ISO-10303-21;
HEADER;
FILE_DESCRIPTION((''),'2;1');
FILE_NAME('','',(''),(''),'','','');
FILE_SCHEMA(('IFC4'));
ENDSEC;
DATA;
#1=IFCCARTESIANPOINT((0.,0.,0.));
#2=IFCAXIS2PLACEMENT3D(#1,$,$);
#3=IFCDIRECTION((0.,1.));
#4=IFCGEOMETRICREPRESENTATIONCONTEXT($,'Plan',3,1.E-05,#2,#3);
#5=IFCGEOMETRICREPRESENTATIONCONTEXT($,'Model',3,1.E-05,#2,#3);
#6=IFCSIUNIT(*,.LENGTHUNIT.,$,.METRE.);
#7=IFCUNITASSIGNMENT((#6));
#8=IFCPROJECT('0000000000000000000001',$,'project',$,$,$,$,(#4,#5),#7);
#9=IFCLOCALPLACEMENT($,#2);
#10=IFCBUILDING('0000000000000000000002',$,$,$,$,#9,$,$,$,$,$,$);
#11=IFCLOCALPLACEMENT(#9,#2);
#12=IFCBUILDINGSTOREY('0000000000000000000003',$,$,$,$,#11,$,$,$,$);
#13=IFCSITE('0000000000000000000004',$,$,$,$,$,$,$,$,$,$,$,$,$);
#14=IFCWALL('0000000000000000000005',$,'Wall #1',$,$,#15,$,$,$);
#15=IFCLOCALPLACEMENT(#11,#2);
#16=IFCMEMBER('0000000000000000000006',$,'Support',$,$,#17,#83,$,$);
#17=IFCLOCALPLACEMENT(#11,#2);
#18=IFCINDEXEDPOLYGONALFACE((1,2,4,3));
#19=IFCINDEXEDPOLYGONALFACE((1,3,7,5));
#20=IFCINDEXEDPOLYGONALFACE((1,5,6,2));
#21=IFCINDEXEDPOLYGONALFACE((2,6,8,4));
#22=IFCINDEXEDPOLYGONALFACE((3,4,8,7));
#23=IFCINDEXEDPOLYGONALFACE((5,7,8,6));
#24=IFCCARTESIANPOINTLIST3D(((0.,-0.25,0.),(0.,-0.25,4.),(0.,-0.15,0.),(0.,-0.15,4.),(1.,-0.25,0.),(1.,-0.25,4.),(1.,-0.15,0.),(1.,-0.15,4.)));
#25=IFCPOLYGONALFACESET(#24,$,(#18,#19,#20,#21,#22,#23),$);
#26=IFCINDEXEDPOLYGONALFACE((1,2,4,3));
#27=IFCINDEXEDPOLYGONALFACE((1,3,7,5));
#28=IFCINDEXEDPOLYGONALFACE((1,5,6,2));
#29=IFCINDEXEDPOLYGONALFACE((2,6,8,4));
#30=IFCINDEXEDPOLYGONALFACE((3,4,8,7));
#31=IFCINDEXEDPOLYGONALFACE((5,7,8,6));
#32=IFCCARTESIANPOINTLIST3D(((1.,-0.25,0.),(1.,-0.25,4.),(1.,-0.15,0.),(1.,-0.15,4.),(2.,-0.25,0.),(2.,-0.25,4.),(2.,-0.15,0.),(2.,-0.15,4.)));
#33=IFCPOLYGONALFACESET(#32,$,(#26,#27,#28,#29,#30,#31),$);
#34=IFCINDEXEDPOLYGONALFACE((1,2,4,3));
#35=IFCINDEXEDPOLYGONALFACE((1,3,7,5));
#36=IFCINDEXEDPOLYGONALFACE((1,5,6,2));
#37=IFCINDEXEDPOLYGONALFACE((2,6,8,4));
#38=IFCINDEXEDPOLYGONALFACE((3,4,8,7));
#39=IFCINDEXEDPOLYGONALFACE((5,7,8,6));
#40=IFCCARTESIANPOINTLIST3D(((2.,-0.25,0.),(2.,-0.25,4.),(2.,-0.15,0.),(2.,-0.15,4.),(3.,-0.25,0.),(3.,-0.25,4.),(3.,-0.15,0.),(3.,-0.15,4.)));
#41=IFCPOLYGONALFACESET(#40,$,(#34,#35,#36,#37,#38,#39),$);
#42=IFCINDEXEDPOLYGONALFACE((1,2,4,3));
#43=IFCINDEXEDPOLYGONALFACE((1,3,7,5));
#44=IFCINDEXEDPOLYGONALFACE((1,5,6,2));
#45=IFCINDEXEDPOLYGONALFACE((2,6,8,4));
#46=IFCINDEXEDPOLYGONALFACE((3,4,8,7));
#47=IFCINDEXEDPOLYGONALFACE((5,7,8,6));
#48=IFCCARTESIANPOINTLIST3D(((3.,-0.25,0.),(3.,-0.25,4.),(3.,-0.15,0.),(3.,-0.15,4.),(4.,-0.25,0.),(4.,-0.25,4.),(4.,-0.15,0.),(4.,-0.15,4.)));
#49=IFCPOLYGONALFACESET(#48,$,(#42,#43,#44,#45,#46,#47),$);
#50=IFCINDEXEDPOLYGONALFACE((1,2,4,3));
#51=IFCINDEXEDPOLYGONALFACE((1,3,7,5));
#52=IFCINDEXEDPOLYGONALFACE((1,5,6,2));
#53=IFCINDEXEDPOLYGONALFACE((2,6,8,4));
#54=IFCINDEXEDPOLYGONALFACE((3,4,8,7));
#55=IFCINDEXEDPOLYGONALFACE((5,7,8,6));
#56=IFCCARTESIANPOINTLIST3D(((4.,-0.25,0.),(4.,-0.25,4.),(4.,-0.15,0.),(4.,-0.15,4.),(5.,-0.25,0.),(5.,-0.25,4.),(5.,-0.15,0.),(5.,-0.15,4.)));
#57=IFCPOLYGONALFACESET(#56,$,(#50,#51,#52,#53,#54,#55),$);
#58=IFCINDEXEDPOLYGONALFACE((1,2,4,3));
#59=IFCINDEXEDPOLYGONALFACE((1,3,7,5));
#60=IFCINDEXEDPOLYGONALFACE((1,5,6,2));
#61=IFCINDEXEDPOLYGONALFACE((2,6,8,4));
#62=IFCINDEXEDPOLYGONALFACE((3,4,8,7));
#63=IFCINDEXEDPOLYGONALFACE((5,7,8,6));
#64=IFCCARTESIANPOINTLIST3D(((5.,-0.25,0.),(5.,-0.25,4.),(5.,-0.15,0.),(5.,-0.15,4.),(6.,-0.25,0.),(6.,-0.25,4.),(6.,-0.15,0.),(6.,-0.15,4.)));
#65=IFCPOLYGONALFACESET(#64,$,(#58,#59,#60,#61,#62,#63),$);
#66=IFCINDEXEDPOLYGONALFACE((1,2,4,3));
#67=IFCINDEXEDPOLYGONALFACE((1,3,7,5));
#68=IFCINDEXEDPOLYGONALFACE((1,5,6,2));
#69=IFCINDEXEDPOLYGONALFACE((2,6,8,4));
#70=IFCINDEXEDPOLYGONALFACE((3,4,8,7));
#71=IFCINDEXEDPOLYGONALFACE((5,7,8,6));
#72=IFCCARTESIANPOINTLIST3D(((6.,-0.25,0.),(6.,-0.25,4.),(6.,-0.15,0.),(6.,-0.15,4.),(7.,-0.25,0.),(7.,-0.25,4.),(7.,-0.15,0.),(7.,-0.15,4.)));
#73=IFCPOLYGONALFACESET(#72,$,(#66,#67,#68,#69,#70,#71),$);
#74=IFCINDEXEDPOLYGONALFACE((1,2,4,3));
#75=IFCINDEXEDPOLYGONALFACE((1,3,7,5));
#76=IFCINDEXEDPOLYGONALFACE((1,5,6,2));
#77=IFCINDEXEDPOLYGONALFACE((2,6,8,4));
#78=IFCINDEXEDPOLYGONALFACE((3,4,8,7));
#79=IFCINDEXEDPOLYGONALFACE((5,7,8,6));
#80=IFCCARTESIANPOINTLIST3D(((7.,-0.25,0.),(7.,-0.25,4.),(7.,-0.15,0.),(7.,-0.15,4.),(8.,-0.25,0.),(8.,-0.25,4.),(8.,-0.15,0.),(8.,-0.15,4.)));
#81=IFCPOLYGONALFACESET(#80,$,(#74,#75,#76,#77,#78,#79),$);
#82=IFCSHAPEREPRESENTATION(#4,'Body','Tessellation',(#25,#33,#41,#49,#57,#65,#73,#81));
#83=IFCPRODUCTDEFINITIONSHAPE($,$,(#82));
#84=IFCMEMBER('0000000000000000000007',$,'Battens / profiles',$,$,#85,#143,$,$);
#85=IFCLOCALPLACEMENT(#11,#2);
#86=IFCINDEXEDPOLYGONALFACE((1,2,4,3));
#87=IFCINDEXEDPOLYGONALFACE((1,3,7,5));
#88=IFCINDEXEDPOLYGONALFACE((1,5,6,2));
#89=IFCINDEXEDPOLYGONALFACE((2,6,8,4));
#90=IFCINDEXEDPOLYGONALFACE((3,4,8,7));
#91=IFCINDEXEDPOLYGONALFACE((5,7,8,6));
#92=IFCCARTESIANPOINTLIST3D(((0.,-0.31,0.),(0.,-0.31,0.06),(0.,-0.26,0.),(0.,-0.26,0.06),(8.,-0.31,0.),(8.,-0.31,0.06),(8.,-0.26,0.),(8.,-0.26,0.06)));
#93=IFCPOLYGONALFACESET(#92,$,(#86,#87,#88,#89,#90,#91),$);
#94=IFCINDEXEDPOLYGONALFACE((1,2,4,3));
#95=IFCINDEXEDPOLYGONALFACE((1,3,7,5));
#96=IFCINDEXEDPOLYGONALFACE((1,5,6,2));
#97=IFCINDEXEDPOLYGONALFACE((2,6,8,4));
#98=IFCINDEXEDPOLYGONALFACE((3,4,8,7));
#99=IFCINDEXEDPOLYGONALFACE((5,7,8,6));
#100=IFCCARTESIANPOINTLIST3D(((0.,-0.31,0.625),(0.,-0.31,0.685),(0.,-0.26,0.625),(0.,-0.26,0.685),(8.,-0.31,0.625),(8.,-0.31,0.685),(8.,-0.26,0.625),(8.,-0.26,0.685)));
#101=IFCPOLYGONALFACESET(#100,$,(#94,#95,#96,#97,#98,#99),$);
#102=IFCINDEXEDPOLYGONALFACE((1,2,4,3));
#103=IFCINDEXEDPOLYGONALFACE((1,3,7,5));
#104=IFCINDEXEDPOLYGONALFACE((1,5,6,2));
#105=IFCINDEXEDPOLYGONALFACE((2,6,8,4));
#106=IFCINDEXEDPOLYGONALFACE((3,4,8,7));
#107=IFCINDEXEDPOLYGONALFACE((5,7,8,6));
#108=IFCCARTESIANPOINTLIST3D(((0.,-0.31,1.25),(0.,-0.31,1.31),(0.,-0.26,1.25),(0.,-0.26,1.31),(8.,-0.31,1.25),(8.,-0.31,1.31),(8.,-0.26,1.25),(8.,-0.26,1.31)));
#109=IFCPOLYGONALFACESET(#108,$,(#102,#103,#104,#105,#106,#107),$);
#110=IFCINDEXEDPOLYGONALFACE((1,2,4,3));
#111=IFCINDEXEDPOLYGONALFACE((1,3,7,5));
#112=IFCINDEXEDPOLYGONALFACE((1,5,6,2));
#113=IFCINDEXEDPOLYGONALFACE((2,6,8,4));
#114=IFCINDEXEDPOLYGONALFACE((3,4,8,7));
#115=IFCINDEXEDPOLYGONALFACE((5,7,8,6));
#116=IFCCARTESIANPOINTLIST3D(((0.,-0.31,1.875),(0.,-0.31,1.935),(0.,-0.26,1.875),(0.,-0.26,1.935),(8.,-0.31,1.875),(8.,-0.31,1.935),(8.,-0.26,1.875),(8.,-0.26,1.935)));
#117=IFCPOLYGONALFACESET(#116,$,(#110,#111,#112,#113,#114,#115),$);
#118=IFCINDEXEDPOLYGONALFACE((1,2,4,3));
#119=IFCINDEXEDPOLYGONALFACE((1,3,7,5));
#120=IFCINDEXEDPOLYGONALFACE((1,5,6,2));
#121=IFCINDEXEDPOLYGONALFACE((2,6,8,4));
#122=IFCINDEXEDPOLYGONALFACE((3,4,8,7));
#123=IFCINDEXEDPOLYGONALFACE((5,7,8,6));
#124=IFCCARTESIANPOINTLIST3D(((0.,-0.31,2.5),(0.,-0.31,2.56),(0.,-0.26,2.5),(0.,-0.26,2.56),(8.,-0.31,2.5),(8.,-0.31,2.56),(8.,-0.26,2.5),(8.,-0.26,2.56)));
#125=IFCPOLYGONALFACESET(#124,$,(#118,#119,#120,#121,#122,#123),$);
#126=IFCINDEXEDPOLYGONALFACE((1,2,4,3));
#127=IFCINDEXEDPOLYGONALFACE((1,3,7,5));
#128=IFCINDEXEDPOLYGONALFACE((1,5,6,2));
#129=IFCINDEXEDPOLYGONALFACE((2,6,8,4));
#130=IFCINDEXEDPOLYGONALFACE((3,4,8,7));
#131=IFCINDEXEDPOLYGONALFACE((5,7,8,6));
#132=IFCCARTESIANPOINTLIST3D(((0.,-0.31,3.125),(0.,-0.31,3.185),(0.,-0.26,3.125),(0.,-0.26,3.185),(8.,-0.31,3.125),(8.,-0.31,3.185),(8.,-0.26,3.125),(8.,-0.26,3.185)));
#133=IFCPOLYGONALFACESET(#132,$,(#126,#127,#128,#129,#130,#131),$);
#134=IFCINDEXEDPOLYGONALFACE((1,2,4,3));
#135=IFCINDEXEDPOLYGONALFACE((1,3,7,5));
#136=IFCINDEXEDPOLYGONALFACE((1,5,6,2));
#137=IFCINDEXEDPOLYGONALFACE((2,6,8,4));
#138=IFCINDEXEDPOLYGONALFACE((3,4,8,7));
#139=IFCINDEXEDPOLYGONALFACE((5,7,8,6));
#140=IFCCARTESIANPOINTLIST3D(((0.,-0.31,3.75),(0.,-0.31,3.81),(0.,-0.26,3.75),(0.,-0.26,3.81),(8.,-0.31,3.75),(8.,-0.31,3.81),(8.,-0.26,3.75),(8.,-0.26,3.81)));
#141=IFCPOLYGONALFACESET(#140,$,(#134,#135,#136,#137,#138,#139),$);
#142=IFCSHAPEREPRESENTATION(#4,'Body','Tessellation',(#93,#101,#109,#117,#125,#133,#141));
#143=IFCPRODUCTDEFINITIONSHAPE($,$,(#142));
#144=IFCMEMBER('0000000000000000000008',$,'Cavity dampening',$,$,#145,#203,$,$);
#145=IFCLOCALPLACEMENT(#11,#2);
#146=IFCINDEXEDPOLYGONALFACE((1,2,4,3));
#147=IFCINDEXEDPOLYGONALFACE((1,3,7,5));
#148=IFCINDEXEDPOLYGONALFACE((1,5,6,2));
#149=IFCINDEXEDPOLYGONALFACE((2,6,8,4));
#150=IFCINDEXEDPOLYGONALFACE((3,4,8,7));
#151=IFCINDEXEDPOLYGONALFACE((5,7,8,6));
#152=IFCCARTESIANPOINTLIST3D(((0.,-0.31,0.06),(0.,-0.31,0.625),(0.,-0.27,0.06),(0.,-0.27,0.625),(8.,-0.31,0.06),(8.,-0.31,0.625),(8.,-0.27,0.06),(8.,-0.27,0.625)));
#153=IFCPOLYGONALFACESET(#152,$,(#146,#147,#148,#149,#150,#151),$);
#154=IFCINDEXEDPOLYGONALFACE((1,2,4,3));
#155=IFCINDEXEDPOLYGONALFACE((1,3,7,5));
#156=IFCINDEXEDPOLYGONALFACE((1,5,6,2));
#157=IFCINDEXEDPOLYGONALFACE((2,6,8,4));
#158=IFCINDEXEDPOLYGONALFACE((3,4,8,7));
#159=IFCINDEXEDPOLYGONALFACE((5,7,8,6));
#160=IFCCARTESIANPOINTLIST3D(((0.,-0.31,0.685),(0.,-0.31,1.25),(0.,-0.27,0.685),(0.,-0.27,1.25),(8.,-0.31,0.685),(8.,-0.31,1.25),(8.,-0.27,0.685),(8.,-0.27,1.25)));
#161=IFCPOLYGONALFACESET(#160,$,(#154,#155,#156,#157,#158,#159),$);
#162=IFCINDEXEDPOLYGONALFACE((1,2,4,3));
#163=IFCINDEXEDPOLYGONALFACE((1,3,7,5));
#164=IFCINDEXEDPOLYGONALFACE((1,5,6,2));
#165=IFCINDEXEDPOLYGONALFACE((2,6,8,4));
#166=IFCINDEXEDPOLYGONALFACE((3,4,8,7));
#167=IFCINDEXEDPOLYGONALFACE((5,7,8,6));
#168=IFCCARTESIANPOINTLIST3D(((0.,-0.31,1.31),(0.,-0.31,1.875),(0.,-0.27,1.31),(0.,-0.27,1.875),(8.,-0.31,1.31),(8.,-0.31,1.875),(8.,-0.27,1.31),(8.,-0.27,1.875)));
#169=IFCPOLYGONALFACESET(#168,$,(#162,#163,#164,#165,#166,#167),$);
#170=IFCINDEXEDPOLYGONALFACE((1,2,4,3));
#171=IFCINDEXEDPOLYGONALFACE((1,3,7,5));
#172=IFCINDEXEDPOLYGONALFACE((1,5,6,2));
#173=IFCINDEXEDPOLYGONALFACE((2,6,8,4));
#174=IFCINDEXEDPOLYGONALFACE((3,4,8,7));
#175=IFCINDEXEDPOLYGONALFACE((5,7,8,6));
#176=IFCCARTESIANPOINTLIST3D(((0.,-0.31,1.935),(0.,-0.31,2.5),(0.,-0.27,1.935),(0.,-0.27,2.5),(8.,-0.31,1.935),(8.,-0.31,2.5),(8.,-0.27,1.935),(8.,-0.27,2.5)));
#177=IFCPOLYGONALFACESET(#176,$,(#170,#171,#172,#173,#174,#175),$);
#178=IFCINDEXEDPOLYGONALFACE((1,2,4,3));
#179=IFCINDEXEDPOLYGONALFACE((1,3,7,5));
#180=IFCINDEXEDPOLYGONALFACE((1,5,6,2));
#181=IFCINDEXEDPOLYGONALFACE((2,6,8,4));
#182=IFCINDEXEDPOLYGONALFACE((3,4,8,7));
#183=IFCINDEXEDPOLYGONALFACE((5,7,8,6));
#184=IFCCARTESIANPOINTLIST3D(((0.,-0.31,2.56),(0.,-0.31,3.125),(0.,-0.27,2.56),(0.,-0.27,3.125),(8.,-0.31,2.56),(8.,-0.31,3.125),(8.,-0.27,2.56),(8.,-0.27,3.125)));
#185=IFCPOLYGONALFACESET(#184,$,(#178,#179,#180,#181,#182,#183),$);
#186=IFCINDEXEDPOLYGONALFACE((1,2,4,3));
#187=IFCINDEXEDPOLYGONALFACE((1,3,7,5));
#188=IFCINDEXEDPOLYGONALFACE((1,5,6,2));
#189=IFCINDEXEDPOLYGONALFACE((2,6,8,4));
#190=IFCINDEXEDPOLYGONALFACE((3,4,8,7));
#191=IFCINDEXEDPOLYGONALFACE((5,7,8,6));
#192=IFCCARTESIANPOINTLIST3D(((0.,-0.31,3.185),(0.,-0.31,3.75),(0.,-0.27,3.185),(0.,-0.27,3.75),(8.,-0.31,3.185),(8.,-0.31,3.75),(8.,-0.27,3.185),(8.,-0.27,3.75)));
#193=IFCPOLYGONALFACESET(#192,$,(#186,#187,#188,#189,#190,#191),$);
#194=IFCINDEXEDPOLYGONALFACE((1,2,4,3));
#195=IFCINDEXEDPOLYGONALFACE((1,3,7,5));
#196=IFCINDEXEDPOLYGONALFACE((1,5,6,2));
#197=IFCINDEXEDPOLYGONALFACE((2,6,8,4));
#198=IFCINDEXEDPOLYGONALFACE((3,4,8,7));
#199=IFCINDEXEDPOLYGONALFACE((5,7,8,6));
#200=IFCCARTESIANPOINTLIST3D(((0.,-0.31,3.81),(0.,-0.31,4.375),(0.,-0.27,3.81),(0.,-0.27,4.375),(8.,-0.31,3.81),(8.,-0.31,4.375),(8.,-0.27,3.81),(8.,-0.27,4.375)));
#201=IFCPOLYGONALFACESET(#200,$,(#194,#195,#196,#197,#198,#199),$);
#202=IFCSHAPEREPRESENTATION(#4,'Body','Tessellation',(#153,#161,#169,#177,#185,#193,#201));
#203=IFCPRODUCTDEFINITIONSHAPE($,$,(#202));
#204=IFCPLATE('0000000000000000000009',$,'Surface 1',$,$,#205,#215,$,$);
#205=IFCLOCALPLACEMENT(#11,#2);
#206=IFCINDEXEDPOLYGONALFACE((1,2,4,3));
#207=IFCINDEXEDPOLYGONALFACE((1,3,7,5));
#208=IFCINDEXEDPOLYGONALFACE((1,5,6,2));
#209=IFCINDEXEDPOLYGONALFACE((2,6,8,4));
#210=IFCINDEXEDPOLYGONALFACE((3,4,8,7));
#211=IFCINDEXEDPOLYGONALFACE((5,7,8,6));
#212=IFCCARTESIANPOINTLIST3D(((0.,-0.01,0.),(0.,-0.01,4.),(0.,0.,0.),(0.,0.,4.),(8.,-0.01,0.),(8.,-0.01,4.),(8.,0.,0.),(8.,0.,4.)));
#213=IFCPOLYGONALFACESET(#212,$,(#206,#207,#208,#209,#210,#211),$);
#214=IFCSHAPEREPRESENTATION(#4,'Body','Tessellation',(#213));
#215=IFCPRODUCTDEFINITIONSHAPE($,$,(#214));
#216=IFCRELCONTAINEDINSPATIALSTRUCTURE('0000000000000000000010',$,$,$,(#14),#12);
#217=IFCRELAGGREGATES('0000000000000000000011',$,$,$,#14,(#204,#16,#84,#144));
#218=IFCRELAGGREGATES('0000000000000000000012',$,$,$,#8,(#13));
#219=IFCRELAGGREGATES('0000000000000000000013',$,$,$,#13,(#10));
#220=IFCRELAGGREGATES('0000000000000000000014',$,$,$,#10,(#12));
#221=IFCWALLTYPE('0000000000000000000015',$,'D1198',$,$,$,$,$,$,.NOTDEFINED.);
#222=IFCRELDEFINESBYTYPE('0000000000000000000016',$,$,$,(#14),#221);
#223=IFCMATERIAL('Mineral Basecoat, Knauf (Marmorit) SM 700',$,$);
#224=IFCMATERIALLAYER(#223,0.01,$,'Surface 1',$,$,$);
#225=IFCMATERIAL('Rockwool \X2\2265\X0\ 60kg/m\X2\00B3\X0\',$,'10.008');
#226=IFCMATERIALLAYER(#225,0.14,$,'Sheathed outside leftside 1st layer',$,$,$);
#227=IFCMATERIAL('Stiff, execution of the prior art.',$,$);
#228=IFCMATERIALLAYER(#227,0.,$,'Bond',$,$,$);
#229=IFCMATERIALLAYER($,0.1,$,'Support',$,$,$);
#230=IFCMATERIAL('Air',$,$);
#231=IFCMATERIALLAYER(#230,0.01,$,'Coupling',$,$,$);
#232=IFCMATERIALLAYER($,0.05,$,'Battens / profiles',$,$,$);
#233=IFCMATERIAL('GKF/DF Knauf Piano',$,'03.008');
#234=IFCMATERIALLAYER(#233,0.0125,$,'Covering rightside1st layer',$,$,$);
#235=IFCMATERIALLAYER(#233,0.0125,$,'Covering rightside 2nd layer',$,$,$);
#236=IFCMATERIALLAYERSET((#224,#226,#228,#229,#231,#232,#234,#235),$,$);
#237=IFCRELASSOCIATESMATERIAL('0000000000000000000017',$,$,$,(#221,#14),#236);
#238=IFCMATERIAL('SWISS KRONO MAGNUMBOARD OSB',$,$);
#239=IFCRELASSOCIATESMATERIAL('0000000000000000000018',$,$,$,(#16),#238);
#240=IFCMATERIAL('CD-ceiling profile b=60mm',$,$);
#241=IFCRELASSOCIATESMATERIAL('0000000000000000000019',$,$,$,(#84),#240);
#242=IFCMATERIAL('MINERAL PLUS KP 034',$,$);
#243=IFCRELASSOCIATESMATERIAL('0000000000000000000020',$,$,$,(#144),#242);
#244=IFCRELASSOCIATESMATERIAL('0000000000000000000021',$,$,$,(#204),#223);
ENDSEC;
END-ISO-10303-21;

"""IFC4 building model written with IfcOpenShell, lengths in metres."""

from ifc_helpers import new_model, si_unit, direction, frame, frame_2d, origin, origin_with_axes, place, context, project, spatial, rectangle, extrude, material, layer, layer_set, type_object, element, aggregate, save


model = new_model("IFC4")

# Units and contexts
plan_context = context("Plan", 3, precision=1e-05, world=origin(), true_north=direction((0.0, 1.0)))
model_context = context("Model", 3, precision=1e-05, world=origin(), true_north=direction((0.0, 1.0)))
ifc_project = project(units=[si_unit("LENGTHUNIT", "METRE")], contexts=[plan_context, model_context])

# Site, building, storey
site = spatial("IfcSite", under=ifc_project)
building_placement = place(None, origin())
building = spatial("IfcBuilding", under=site, at=building_placement)
storey_placement = place(building_placement, origin())
storey = spatial("IfcBuildingStorey", under=building, at=storey_placement)

# Wall, members, plate
ifc_material_1 = material(Name="Mineral Basecoat, Knauf (Marmorit) SM 700")
ifc_layer_1 = layer(ifc_material_1, 0.01, Name="Surface 1")
ifc_material_2 = material(Name="Rockwool ≥ 60kg/m³", Category="10.008")
ifc_layer_2 = layer(ifc_material_2, 0.14, Name="Sheathed outside leftside 1st layer")
ifc_material_3 = material(Name="Stiff, execution of the prior art.")
ifc_layer_3 = layer(ifc_material_3, 0.0, Name="Bond")
ifc_layer_4 = layer(None, 0.1, Name="Support")
ifc_material_4 = material(Name="Air")
ifc_layer_5 = layer(ifc_material_4, 0.01, Name="Coupling")
ifc_layer_6 = layer(None, 0.05, Name="Battens / profiles")
ifc_material_5 = material(Name="GKF/DF Knauf Piano", Category="03.008")
ifc_layer_7 = layer(ifc_material_5, 0.0125, Name="Covering rightside1st layer")
ifc_layer_8 = layer(ifc_material_5, 0.0125, Name="Covering rightside 2nd layer")
ifc_layer_set = layer_set([ifc_layer_1, ifc_layer_2, ifc_layer_3, ifc_layer_4, ifc_layer_5, ifc_layer_6, ifc_layer_7, ifc_layer_8])
wall_type = type_object("IfcWallType", Name="D1198", PredefinedType="NOTDEFINED", material=ifc_layer_set)
wall_placement = place(None, frame((0.0, 0.0, 0.0), z_axis=(0.0, -1.0, 0.0), x_axis=(1.0, 0.0, 0.0)))
wall = element("IfcWall", 1, at=wall_placement, inside=storey, type_object=wall_type, material=ifc_layer_set, Name="Wall #1")
ifc_material_6 = material(Name="SWISS KRONO MAGNUMBOARD OSB")
member_1_placement = place(wall_placement, origin())
member_1 = element("IfcMember", 2, at=member_1_placement, material=ifc_material_6, Name="Support", context=plan_context, shape_type="SweptSolid", body=[
    extrude(rectangle(XDim=1.0, YDim=0.1, at=frame_2d((0.5, 0.05), x_axis=(1.0, 0.0))), frame((0.0, 4.0, 0.15), z_axis=(0.0, -1.0, 0.0), x_axis=(1.0, 0.0, 0.0)), (0.0, 0.0, 1.0), 4.0),
    extrude(rectangle(XDim=1.0, YDim=0.1, at=frame_2d((0.5, 0.05), x_axis=(1.0, 0.0))), frame((1.0, 4.0, 0.15), z_axis=(0.0, -1.0, 0.0), x_axis=(1.0, 0.0, 0.0)), (0.0, 0.0, 1.0), 4.0),
    extrude(rectangle(XDim=1.0, YDim=0.1, at=frame_2d((0.5, 0.05), x_axis=(1.0, 0.0))), frame((2.0, 4.0, 0.15), z_axis=(0.0, -1.0, 0.0), x_axis=(1.0, 0.0, 0.0)), (0.0, 0.0, 1.0), 4.0),
    extrude(rectangle(XDim=1.0, YDim=0.1, at=frame_2d((0.5, 0.05), x_axis=(1.0, 0.0))), frame((3.0, 4.0, 0.15), z_axis=(0.0, -1.0, 0.0), x_axis=(1.0, 0.0, 0.0)), (0.0, 0.0, 1.0), 4.0),
    extrude(rectangle(XDim=1.0, YDim=0.1, at=frame_2d((0.5, 0.05), x_axis=(1.0, 0.0))), frame((4.0, 4.0, 0.15), z_axis=(0.0, -1.0, 0.0), x_axis=(1.0, 0.0, 0.0)), (0.0, 0.0, 1.0), 4.0),
    extrude(rectangle(XDim=1.0, YDim=0.1, at=frame_2d((0.5, 0.05), x_axis=(1.0, 0.0))), frame((5.0, 4.0, 0.15), z_axis=(0.0, -1.0, 0.0), x_axis=(1.0, 0.0, 0.0)), (0.0, 0.0, 1.0), 4.0),
    extrude(rectangle(XDim=1.0, YDim=0.1, at=frame_2d((0.5, 0.05), x_axis=(1.0, 0.0))), frame((6.0, 4.0, 0.15), z_axis=(0.0, -1.0, 0.0), x_axis=(1.0, 0.0, 0.0)), (0.0, 0.0, 1.0), 4.0),
    extrude(rectangle(XDim=1.0, YDim=0.1, at=frame_2d((0.5, 0.05), x_axis=(1.0, 0.0))), frame((7.0, 4.0, 0.15), z_axis=(0.0, -1.0, 0.0), x_axis=(1.0, 0.0, 0.0)), (0.0, 0.0, 1.0), 4.0),
])
ifc_material_7 = material(Name="CD-ceiling profile b=60mm")
member_2_placement = place(wall_placement, origin())
member_2 = element("IfcMember", 3, at=member_2_placement, material=ifc_material_7, Name="Battens / profiles", context=plan_context, shape_type="SweptSolid", body=[
    extrude(rectangle(XDim=0.06, YDim=0.05, at=frame_2d((0.03, 0.025), x_axis=(1.0, 0.0))), frame((0.0, 0.0, 0.26), z_axis=(1.0, 0.0, 0.0), x_axis=(0.0, 1.0, 0.0)), (0.0, 0.0, 1.0), 8.0),
    extrude(rectangle(XDim=0.06, YDim=0.05, at=frame_2d((0.03, 0.025), x_axis=(1.0, 0.0))), frame((0.0, 0.625, 0.26), z_axis=(1.0, 0.0, 0.0), x_axis=(0.0, 1.0, 0.0)), (0.0, 0.0, 1.0), 8.0),
    extrude(rectangle(XDim=0.06, YDim=0.05, at=frame_2d((0.03, 0.025), x_axis=(1.0, 0.0))), frame((0.0, 1.25, 0.26), z_axis=(1.0, 0.0, 0.0), x_axis=(0.0, 1.0, 0.0)), (0.0, 0.0, 1.0), 8.0),
    extrude(rectangle(XDim=0.06, YDim=0.05, at=frame_2d((0.03, 0.025), x_axis=(1.0, 0.0))), frame((0.0, 1.875, 0.26), z_axis=(1.0, 0.0, 0.0), x_axis=(0.0, 1.0, 0.0)), (0.0, 0.0, 1.0), 8.0),
    extrude(rectangle(XDim=0.06, YDim=0.05, at=frame_2d((0.03, 0.025), x_axis=(1.0, 0.0))), frame((0.0, 2.5, 0.26), z_axis=(1.0, 0.0, 0.0), x_axis=(0.0, 1.0, 0.0)), (0.0, 0.0, 1.0), 8.0),
    extrude(rectangle(XDim=0.06, YDim=0.05, at=frame_2d((0.03, 0.025), x_axis=(1.0, 0.0))), frame((0.0, 3.125, 0.26), z_axis=(1.0, 0.0, 0.0), x_axis=(0.0, 1.0, 0.0)), (0.0, 0.0, 1.0), 8.0),
    extrude(rectangle(XDim=0.06, YDim=0.05, at=frame_2d((0.03, 0.025), x_axis=(1.0, 0.0))), frame((0.0, 3.75, 0.26), z_axis=(1.0, 0.0, 0.0), x_axis=(0.0, 1.0, 0.0)), (0.0, 0.0, 1.0), 8.0),
])
ifc_material_8 = material(Name="MINERAL PLUS KP 034")
member_3_placement = place(wall_placement, origin())
member_3 = element("IfcMember", 4, at=member_3_placement, material=ifc_material_8, Name="Cavity dampening", context=plan_context, shape_type="SweptSolid", body=[
    extrude(rectangle(XDim=0.565, YDim=0.04, at=frame_2d((0.2825, 0.02), x_axis=(1.0, 0.0))), frame((0.0, 0.06, 0.27), z_axis=(1.0, 0.0, 0.0), x_axis=(0.0, 1.0, 0.0)), (0.0, 0.0, 1.0), 8.0),
    extrude(rectangle(XDim=0.565, YDim=0.04, at=frame_2d((0.2825, 0.02), x_axis=(1.0, 0.0))), frame((0.0, 0.685, 0.27), z_axis=(1.0, 0.0, 0.0), x_axis=(0.0, 1.0, 0.0)), (0.0, 0.0, 1.0), 8.0),
    extrude(rectangle(XDim=0.565, YDim=0.04, at=frame_2d((0.2825, 0.02), x_axis=(1.0, 0.0))), frame((0.0, 1.31, 0.27), z_axis=(1.0, 0.0, 0.0), x_axis=(0.0, 1.0, 0.0)), (0.0, 0.0, 1.0), 8.0),
    extrude(rectangle(XDim=0.565, YDim=0.04, at=frame_2d((0.2825, 0.02), x_axis=(1.0, 0.0))), frame((0.0, 1.935, 0.27), z_axis=(1.0, 0.0, 0.0), x_axis=(0.0, 1.0, 0.0)), (0.0, 0.0, 1.0), 8.0),
    extrude(rectangle(XDim=0.565, YDim=0.04, at=frame_2d((0.2825, 0.02), x_axis=(1.0, 0.0))), frame((0.0, 2.56, 0.27), z_axis=(1.0, 0.0, 0.0), x_axis=(0.0, 1.0, 0.0)), (0.0, 0.0, 1.0), 8.0),
    extrude(rectangle(XDim=0.565, YDim=0.04, at=frame_2d((0.2825, 0.02), x_axis=(1.0, 0.0))), frame((0.0, 3.185, 0.27), z_axis=(1.0, 0.0, 0.0), x_axis=(0.0, 1.0, 0.0)), (0.0, 0.0, 1.0), 8.0),
    extrude(rectangle(XDim=0.565, YDim=0.04, at=frame_2d((0.2825, 0.02), x_axis=(1.0, 0.0))), frame((0.0, 3.81, 0.27), z_axis=(1.0, 0.0, 0.0), x_axis=(0.0, 1.0, 0.0)), (0.0, 0.0, 1.0), 8.0),
])
plate_1_placement = place(wall_placement, origin())
plate_1 = element("IfcPlate", 5, at=plate_1_placement, material=ifc_material_1, Name="Surface 1", context=plan_context, shape_type="SweptSolid", body=[
    extrude(rectangle(XDim=8.0, YDim=4.0, at=frame_2d((4.0, 2.0), x_axis=(1.0, 0.0))), origin_with_axes(), (0.0, 0.0, 1.0), 0.01),
])
aggregate(wall, [plate_1, member_1, member_2, member_3])

save(model, "model.ifc")
